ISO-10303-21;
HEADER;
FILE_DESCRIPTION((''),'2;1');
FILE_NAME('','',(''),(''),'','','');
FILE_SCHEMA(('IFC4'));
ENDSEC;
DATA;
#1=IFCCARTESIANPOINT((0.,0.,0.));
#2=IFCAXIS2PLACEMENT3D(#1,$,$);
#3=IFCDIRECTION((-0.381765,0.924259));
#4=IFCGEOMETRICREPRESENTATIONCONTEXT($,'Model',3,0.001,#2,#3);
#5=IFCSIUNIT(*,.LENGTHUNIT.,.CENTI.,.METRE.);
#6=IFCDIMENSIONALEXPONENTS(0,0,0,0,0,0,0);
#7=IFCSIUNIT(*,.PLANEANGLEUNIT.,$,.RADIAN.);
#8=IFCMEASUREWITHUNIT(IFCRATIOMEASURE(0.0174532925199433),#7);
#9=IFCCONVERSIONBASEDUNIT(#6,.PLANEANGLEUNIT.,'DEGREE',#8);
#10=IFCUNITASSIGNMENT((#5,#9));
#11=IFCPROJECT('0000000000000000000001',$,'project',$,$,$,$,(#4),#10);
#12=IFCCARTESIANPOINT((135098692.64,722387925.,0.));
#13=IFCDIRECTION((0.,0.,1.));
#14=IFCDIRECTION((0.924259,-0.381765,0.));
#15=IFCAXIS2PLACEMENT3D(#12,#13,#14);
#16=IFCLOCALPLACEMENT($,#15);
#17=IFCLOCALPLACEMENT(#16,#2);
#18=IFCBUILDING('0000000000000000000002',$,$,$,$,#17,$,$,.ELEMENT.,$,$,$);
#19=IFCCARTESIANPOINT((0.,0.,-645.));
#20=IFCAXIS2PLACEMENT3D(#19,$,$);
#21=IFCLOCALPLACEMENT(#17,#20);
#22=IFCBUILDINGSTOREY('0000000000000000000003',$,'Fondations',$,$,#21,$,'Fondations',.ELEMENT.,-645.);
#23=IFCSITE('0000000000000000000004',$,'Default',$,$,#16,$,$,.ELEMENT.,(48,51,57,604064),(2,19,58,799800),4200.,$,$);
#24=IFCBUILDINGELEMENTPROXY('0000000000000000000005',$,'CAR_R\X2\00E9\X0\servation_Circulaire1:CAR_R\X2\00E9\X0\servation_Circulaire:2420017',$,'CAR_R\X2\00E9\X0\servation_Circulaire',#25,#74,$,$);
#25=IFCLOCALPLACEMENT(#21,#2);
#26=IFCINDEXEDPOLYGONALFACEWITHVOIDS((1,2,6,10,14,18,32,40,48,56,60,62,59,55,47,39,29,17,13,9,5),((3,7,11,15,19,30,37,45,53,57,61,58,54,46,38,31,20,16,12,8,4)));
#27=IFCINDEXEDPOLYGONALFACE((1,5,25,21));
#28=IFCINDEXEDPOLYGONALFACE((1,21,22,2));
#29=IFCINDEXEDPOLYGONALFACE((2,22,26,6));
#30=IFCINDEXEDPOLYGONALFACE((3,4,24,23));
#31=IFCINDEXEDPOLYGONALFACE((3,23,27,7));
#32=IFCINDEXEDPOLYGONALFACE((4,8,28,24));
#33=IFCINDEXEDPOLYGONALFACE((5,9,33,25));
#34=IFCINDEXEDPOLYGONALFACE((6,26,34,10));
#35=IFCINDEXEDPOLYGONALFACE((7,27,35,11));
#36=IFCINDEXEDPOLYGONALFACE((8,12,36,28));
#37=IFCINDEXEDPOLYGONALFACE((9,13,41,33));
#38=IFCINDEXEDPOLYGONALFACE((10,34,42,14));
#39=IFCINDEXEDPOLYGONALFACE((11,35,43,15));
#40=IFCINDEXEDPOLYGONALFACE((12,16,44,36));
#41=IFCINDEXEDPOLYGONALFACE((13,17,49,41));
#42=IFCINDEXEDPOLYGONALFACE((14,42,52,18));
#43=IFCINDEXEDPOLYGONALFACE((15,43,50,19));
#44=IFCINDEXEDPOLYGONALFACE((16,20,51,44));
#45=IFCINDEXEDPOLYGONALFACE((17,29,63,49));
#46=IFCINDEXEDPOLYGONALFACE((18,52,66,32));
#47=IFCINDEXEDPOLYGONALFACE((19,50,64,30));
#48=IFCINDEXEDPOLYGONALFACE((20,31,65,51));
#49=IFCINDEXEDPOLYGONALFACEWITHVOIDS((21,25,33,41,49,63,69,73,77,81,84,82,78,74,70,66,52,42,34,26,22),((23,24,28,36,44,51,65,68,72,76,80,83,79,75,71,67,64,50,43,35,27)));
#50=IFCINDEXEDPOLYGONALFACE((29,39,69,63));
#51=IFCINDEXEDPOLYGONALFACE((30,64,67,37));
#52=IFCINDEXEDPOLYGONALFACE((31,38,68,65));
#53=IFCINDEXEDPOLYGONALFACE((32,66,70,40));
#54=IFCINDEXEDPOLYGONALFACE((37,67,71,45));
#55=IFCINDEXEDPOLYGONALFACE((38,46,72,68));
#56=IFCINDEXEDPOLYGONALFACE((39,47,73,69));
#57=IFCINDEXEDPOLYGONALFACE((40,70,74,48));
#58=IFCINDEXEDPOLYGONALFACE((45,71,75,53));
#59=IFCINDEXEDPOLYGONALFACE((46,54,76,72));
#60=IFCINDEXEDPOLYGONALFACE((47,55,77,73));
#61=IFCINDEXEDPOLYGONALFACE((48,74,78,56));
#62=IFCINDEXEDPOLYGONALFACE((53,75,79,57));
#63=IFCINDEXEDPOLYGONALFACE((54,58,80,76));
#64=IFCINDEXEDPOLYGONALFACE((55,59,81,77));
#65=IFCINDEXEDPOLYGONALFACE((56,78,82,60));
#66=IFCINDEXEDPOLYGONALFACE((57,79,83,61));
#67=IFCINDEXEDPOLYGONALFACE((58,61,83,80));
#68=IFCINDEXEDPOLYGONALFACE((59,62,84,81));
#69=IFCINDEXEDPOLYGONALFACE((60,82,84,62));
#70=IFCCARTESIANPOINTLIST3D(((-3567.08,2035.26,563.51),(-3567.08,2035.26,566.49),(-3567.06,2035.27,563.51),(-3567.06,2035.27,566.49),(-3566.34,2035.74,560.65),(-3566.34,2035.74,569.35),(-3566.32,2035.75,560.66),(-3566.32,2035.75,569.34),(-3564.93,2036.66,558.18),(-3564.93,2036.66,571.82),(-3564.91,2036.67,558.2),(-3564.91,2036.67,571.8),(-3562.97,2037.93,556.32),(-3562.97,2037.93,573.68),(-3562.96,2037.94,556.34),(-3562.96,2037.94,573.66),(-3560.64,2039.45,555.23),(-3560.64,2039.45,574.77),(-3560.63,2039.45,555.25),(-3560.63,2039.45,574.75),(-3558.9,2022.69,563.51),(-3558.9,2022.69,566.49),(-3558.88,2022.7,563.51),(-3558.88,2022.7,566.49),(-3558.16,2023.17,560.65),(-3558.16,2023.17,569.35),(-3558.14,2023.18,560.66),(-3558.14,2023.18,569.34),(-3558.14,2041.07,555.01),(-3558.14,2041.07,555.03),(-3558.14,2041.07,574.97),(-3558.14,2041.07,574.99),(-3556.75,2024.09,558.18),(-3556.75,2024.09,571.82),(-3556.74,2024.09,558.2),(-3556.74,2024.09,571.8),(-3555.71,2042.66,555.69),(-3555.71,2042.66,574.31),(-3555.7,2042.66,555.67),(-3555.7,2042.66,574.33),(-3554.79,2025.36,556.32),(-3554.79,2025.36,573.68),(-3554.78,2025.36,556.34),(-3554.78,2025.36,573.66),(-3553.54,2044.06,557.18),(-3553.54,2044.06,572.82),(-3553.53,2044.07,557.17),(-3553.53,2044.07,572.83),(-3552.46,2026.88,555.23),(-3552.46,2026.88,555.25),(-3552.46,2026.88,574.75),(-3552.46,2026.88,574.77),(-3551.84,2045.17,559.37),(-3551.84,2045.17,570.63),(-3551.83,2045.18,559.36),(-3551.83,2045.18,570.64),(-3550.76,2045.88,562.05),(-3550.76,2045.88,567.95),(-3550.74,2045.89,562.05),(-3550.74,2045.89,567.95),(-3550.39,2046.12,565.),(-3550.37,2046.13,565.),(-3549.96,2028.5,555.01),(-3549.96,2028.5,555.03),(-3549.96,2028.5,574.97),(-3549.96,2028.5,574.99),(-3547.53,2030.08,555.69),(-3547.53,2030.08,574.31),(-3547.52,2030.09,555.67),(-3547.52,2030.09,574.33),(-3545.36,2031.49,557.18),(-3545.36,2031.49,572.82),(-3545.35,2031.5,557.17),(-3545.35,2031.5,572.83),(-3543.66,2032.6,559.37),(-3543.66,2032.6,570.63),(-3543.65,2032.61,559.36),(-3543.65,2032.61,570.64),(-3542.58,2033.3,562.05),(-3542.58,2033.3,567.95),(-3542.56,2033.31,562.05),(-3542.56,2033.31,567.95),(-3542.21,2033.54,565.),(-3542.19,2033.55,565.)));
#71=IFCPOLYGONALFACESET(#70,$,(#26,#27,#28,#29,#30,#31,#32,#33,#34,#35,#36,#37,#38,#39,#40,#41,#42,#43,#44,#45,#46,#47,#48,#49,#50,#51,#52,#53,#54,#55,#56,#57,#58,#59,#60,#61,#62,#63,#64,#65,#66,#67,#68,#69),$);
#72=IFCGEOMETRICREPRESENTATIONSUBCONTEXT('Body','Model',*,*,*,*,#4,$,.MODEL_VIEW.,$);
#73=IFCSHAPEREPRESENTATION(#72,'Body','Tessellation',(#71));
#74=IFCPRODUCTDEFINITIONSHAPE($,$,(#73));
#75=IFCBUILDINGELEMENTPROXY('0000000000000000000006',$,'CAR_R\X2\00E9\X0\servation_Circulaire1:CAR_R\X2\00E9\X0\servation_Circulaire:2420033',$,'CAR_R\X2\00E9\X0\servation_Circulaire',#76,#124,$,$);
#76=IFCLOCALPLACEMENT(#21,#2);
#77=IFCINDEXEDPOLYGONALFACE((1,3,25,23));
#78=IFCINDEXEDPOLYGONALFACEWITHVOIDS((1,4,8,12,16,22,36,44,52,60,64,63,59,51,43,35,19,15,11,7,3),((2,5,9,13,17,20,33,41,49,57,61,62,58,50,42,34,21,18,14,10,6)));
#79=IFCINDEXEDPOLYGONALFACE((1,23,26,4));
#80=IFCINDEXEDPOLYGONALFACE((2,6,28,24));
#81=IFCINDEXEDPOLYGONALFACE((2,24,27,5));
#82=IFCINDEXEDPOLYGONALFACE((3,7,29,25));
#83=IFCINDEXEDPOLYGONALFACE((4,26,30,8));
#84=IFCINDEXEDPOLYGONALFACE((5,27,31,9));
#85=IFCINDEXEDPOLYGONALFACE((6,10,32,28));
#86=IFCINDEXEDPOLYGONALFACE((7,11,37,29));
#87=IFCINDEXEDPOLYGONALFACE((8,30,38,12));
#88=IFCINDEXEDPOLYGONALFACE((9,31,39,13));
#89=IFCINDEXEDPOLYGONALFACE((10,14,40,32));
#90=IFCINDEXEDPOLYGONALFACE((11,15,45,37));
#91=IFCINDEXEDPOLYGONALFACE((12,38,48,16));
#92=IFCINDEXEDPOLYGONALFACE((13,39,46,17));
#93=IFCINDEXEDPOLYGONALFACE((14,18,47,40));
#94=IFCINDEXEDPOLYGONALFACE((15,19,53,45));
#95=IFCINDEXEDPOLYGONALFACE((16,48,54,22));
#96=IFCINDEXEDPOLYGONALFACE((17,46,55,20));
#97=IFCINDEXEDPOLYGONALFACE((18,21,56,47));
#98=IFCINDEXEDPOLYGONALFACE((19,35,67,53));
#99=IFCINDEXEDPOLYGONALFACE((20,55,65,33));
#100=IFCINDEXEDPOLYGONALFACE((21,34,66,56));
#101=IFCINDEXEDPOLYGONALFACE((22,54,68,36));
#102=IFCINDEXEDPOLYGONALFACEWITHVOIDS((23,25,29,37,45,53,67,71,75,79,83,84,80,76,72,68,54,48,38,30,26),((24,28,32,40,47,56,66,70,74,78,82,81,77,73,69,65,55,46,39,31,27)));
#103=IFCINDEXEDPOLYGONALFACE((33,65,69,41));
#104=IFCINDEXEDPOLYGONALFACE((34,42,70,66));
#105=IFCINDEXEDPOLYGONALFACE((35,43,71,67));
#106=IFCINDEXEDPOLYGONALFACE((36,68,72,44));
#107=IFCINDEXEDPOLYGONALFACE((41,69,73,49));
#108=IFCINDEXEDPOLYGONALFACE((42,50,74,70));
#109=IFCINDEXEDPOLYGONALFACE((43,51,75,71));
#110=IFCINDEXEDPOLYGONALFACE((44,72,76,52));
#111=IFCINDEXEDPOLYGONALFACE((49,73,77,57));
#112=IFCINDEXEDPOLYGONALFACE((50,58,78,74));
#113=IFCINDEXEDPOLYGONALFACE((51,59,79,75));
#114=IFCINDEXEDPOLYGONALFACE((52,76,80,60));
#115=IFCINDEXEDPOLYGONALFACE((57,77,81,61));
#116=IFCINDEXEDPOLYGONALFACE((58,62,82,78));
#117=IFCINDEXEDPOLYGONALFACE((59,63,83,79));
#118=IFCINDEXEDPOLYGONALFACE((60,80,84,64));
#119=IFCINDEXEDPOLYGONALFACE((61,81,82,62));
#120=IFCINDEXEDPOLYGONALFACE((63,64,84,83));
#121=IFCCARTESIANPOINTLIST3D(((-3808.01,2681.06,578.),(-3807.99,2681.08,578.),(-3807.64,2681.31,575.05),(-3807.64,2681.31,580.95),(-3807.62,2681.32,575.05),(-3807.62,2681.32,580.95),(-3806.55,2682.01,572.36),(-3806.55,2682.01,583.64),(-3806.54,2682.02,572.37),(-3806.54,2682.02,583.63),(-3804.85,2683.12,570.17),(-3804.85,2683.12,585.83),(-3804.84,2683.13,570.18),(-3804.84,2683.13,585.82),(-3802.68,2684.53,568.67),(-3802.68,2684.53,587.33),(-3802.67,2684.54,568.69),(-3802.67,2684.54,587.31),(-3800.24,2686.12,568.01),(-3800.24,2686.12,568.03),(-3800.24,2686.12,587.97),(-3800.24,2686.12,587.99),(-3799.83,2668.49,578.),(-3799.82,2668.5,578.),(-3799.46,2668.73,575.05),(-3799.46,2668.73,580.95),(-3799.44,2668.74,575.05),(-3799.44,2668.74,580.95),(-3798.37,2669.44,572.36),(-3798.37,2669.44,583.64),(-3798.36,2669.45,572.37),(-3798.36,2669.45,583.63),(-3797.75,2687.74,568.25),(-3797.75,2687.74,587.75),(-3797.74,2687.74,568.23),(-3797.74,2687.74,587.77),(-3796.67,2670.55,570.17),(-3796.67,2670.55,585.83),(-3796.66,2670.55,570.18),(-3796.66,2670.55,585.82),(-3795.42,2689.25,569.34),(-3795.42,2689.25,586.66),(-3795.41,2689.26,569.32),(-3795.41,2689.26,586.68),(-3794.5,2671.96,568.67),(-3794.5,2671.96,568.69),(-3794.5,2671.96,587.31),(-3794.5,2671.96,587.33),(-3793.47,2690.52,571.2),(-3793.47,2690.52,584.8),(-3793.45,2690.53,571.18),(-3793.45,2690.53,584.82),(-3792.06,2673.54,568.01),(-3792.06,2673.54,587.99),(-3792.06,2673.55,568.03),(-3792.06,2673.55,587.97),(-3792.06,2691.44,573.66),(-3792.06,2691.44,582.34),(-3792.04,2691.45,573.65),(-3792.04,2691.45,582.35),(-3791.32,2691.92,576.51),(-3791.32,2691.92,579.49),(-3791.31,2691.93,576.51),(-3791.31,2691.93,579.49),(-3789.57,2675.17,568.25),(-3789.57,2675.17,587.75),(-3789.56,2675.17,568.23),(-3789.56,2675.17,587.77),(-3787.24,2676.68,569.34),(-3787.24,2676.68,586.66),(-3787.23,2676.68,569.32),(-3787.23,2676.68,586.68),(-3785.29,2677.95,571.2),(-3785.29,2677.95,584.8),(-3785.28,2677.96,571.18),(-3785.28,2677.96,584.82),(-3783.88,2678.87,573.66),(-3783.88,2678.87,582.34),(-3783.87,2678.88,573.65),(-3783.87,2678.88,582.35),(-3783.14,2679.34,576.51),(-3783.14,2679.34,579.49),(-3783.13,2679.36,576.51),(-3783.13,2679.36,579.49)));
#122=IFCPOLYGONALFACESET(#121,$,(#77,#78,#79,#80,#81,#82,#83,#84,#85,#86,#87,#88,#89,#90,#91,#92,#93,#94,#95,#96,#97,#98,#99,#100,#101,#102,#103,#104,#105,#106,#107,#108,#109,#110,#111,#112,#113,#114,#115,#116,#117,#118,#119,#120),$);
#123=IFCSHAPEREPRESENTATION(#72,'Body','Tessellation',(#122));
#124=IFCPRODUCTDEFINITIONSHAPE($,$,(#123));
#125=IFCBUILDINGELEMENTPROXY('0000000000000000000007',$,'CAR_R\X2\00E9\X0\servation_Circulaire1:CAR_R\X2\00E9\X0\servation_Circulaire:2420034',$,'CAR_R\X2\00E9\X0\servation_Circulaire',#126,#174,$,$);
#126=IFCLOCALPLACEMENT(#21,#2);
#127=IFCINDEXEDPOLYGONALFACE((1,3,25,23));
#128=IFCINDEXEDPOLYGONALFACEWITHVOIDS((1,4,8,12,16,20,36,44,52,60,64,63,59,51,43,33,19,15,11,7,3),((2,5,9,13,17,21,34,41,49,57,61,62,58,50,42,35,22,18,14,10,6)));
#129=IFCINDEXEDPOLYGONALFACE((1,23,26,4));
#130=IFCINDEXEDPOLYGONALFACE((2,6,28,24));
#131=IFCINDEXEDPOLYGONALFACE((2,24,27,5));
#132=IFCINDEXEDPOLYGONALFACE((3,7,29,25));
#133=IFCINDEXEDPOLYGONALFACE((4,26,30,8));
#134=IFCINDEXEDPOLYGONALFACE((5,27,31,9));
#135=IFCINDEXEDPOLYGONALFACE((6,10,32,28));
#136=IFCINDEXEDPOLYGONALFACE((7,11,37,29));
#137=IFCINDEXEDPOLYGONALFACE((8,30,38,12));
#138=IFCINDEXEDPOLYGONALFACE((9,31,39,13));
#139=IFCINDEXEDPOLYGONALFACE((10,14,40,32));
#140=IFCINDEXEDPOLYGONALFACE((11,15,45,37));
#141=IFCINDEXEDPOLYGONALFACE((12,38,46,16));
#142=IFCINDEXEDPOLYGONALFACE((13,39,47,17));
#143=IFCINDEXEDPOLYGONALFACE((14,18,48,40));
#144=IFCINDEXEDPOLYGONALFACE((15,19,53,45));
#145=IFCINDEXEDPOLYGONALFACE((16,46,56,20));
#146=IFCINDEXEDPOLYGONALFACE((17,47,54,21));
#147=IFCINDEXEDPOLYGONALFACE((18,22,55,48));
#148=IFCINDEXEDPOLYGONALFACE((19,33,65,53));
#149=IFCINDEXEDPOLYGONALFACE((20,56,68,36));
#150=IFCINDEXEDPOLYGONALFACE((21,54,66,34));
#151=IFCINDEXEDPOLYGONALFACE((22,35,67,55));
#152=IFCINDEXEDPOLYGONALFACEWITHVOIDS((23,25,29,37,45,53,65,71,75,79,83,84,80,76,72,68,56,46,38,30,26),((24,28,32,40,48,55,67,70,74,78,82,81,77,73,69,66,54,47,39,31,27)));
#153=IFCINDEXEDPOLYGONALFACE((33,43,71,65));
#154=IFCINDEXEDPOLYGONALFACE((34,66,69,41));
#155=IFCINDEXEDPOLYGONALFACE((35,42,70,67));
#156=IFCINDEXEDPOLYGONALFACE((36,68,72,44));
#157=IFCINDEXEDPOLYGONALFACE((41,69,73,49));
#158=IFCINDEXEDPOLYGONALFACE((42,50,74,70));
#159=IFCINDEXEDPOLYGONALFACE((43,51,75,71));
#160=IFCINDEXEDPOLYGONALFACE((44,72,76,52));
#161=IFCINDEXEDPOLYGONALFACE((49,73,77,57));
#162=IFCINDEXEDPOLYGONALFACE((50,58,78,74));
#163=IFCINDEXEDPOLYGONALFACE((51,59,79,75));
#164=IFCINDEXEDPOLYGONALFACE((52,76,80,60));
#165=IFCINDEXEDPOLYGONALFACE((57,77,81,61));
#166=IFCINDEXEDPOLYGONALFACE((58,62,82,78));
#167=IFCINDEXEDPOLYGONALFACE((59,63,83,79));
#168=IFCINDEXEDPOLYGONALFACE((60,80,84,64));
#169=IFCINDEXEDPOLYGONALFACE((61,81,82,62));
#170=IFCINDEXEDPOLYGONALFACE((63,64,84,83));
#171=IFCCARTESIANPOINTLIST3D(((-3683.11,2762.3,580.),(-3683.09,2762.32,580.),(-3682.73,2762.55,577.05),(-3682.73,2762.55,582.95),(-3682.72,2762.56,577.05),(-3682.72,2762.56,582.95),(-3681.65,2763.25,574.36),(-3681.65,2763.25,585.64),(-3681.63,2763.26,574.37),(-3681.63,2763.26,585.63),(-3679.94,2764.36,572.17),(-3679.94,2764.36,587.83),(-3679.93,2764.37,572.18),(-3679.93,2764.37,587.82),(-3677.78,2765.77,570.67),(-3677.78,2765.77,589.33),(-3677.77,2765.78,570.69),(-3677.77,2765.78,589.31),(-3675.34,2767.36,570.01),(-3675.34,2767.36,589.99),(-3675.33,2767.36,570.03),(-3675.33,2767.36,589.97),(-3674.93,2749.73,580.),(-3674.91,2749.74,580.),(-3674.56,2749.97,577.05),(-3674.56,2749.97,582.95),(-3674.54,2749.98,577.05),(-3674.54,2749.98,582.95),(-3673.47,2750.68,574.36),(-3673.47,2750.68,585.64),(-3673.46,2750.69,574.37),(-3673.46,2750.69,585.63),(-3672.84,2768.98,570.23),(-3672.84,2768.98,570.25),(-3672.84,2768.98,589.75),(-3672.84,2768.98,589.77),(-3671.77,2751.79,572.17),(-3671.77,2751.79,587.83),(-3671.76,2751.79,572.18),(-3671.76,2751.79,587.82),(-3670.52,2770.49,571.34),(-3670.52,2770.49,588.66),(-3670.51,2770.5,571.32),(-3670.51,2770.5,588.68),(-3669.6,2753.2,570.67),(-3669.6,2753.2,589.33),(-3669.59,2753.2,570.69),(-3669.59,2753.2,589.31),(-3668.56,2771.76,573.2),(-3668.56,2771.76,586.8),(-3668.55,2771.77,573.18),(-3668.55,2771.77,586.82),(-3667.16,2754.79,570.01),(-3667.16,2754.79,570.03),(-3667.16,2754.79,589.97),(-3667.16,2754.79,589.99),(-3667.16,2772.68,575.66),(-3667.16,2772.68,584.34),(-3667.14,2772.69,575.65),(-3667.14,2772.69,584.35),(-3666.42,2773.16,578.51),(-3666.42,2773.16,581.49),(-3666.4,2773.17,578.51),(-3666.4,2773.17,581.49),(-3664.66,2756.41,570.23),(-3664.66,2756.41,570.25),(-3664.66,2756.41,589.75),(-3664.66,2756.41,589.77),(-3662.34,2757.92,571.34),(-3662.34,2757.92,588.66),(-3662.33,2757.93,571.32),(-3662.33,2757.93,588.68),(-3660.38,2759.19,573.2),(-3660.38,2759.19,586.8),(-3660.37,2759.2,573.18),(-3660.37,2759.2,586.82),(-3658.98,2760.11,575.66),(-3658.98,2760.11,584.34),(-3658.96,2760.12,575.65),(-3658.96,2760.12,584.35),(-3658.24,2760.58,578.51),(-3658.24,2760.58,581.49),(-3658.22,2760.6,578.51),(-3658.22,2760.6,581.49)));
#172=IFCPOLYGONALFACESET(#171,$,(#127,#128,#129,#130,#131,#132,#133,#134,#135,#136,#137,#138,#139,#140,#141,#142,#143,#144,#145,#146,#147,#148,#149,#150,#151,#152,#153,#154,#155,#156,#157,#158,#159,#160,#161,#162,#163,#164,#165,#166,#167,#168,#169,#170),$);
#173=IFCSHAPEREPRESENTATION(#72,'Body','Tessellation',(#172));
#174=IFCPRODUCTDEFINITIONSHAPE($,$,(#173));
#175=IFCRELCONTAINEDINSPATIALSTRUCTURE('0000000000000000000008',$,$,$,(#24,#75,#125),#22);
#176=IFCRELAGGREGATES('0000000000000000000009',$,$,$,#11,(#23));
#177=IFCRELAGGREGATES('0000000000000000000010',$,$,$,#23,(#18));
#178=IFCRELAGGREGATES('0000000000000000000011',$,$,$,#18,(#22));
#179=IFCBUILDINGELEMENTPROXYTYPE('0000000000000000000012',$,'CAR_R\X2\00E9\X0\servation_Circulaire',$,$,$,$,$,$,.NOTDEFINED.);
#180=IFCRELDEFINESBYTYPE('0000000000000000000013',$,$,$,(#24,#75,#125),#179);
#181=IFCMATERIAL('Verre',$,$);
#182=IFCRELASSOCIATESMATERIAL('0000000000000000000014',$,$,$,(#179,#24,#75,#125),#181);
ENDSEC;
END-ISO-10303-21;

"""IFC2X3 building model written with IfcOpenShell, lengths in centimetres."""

from ifc_helpers import new_model, entity, si_unit, converted_unit, direction, frame, frame_2d, origin, place, context, subcontext, project, spatial, hollow_circle, extrude, source, transform, mapped, material, type_object, type_shapes, element, save


model = new_model("IFC2X3")

# Units and contexts
model_context = context("Model", 3, precision=0.001, world=origin(), true_north=direction((-0.381765, 0.924259)))
body_context = subcontext(model_context, "Body", "Model", "MODEL_VIEW")
ifc_project = project(units=[si_unit("LENGTHUNIT", "METRE", prefix="CENTI"), converted_unit("PLANEANGLEUNIT", "DEGREE", entity("IfcRatioMeasure", 0.0174532925199433), si_unit("PLANEANGLEUNIT", "RADIAN"), dimensions=[0, 0, 0, 0, 0, 0, 0])], contexts=[model_context])

# Site, building, storey
site_placement = place(None, frame((135098692.64, 722387925.0, 0.0), z_axis=(0.0, 0.0, 1.0), x_axis=(0.924259, -0.381765, 0.0)))
site = spatial("IfcSite", under=ifc_project, at=site_placement, Name="Default", CompositionType="ELEMENT", RefLatitude=(48, 51, 57, 604064), RefLongitude=(2, 19, 58, 799800), RefElevation=4200.0)
building_placement = place(site_placement, origin())
building = spatial("IfcBuilding", under=site, at=building_placement, CompositionType="ELEMENT")
storey_placement = place(building_placement, frame((0.0, 0.0, -645.0)))
storey = spatial("IfcBuildingStorey", under=building, at=storey_placement, Name="Fondations", LongName="Fondations", CompositionType="ELEMENT", Elevation=-645.0)

# Building element proxies
ifc_material_1 = material(Name="Verre")
building_element_proxy_type_1 = type_object("IfcBuildingElementProxyType", Name="CAR_Réservation_Circulaire", PredefinedType="NOTDEFINED", material=ifc_material_1)
shared_shape_1 = source(origin(), body_context, "Body", "SweptSolid", [
    extrude(hollow_circle(Radius=10.02, WallThickness=0.02, at=frame_2d((0.0, 0.0), x_axis=(1.0, 0.0))), frame((0.0, 0.0, -15.0)), (0.0, 0.0, 1.0), 15.0),
])
type_shapes(building_element_proxy_type_1, [shared_shape_1])
for number, where, z_axis, x_axis, name in (
    (1, (-3550.59, 2028.09, 565.0), (0.545236, -0.838282, 0.0), (0.838282, 0.545236, 0.0), "CAR_Réservation_Circulaire1:CAR_Réservation_Circulaire:2420017"),
    (2, (-3799.61, 2686.53, 578.0), (-0.545236, 0.838282, 0.0), (-0.838282, -0.545236, 0.0), "CAR_Réservation_Circulaire1:CAR_Réservation_Circulaire:2420033"),
    (3, (-3674.71, 2767.77, 580.0), (-0.545236, 0.838282, 0.0), (-0.838282, -0.545236, 0.0), "CAR_Réservation_Circulaire1:CAR_Réservation_Circulaire:2420034"),
):
    element("IfcBuildingElementProxy", number, at=place(storey_placement, frame(where, z_axis=z_axis, x_axis=x_axis)), inside=storey, type_object=building_element_proxy_type_1, material=ifc_material_1, Name=name, ObjectType="CAR_Réservation_Circulaire", context=body_context, shape_type="MappedRepresentation", body=[
        mapped(shared_shape_1, transform((0.0, 0.0, 0.0), scale=1.0)),
    ])

save(model, "model.ifc")
